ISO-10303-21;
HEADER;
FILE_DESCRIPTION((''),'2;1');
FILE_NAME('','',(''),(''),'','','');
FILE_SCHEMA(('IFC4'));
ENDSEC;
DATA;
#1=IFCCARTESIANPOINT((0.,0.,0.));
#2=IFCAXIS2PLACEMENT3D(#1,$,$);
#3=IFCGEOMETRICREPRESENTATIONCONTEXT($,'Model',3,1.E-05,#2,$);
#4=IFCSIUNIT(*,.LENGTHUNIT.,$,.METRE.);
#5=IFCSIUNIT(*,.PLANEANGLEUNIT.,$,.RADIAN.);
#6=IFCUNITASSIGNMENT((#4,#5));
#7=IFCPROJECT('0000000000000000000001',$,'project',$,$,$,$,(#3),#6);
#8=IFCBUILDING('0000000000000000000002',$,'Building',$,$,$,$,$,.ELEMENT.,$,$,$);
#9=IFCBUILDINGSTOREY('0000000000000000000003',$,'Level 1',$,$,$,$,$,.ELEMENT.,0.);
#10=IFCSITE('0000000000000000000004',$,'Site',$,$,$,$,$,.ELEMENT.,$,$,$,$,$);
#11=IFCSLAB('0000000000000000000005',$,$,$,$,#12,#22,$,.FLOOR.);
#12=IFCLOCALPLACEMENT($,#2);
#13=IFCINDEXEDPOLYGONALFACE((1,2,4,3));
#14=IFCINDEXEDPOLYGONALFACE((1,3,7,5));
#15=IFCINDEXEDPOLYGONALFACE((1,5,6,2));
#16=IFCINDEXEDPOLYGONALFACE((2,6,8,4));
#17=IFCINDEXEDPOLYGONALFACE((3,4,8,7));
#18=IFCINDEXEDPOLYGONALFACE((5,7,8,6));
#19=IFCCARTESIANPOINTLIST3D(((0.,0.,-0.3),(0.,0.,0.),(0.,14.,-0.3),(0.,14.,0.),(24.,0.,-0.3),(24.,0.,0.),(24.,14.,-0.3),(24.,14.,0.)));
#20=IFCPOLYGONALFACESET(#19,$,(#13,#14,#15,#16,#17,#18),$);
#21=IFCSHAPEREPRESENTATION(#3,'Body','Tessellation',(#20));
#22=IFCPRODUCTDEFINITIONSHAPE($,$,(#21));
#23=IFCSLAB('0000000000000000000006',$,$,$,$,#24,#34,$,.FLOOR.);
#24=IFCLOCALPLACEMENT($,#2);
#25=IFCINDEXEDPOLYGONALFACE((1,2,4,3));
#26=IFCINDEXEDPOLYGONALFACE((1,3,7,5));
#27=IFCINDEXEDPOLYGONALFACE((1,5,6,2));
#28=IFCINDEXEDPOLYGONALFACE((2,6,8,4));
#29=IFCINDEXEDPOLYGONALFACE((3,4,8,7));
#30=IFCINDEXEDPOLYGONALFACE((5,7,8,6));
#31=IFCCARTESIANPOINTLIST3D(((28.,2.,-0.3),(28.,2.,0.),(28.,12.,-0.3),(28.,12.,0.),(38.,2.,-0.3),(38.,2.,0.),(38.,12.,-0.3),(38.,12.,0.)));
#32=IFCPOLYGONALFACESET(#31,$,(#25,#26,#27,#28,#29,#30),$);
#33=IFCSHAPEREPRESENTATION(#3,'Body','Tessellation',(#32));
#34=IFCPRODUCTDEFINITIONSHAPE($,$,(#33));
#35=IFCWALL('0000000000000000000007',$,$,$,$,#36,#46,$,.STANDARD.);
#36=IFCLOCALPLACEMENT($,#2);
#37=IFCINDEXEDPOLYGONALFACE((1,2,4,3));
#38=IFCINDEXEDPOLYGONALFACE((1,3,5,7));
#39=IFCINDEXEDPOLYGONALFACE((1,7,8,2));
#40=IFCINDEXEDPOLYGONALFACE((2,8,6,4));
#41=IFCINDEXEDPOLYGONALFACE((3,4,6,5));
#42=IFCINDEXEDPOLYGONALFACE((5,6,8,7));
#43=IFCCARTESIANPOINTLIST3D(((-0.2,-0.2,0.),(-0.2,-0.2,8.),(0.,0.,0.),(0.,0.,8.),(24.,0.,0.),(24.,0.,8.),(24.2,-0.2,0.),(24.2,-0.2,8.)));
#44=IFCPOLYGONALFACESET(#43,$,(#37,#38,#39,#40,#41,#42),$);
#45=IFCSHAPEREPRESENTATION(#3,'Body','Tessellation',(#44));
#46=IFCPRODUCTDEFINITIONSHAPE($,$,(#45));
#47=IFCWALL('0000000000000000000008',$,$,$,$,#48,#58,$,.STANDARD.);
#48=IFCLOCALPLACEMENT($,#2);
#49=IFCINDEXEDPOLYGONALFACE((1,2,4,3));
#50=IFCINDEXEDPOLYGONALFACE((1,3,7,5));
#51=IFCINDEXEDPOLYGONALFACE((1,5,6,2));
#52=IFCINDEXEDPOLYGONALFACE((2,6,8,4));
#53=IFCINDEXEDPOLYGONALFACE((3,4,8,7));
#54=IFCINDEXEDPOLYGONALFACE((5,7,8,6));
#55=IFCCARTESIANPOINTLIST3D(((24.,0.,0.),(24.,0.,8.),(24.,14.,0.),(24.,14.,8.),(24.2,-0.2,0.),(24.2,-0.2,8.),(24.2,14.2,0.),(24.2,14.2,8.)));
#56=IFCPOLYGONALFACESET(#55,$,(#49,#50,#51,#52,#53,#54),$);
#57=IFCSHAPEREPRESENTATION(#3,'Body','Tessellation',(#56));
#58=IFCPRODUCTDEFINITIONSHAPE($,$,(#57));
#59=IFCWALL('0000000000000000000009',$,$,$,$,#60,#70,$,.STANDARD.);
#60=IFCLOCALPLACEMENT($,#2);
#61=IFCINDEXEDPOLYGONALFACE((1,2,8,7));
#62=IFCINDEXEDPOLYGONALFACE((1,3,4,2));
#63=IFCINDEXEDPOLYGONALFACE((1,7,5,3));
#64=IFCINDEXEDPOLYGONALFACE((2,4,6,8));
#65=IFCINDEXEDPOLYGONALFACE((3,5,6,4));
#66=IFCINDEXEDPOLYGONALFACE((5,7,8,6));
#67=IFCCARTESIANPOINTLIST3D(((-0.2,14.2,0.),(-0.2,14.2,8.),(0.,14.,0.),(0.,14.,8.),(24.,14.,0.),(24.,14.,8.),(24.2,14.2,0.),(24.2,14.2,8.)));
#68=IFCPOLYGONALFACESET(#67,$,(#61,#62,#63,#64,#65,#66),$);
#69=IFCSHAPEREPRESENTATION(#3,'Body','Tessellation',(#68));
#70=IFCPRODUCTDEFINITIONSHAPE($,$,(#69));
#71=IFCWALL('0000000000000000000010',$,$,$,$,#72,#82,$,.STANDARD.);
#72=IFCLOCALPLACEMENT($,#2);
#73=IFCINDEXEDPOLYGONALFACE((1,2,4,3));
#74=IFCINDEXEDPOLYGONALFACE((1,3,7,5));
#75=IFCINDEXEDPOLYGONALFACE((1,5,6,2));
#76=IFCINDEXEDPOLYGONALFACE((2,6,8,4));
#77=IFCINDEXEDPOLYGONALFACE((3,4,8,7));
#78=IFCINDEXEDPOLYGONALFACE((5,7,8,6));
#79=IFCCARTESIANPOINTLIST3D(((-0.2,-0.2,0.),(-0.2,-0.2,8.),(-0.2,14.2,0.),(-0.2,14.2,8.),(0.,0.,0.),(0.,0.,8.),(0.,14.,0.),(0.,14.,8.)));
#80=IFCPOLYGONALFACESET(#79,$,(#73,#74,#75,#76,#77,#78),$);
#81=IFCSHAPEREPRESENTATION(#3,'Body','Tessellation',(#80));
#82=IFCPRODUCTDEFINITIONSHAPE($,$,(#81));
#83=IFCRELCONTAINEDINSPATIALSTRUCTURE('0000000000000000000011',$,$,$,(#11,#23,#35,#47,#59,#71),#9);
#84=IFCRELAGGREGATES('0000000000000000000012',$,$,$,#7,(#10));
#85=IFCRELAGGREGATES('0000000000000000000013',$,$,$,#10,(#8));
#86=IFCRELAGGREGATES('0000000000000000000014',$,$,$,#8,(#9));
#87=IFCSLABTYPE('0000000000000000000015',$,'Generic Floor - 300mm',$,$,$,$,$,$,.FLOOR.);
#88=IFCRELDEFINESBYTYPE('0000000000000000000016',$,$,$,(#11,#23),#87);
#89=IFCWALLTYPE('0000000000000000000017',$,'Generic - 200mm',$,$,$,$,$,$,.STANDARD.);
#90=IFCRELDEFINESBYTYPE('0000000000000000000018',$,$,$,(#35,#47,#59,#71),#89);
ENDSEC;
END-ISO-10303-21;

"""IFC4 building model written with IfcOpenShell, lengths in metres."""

from ifc_helpers import new_model, si_unit, frame, origin, place, context, project, spatial, polyline, outline, extrude, type_object, element, save


model = new_model("IFC4")

# Units and contexts
model_context = context("Model", 3, precision=1e-05, world=origin())
ifc_project = project(units=[si_unit("LENGTHUNIT", "METRE"), si_unit("PLANEANGLEUNIT", "RADIAN")], contexts=[model_context])

# Site, building, storey
site = spatial("IfcSite", under=ifc_project, Name="Site", CompositionType="ELEMENT")
building = spatial("IfcBuilding", under=site, Name="Building", CompositionType="ELEMENT")
storey = spatial("IfcBuildingStorey", under=building, Name="Level 1", CompositionType="ELEMENT", Elevation=0.0)

# Slabs
slab_type = type_object("IfcSlabType", Name="Generic Floor - 300mm", PredefinedType="FLOOR")
slab_1_placement = place(None, origin())
element("IfcSlab", 1, at=slab_1_placement, inside=storey, type_object=slab_type, PredefinedType="FLOOR", context=model_context, shape_type="SweptSolid", body=[
    extrude(outline(polyline([(0.0, 14.0), (0.0, 0.0), (24.0, 0.0), (24.0, 14.0), (0.0, 14.0)])), origin(), (0.0, 0.0, -1.0), 0.3),
])
slab_2_placement = place(None, origin())
element("IfcSlab", 2, at=slab_2_placement, inside=storey, type_object=slab_type, PredefinedType="FLOOR", context=model_context, shape_type="SweptSolid", body=[
    extrude(outline(polyline([(28.0, 12.0), (28.0, 2.0), (38.0, 2.0), (38.0, 12.0), (28.0, 12.0)])), origin(), (0.0, 0.0, -1.0), 0.3),
])

# Walls
wall_type = type_object("IfcWallType", Name="Generic - 200mm", PredefinedType="STANDARD")
wall_1_placement = place(None, frame((24.0, -0.1, 0.0), z_axis=(0.0, 0.0, 1.0), x_axis=(-1.0, 0.0, 0.0)))
element("IfcWall", 3, at=wall_1_placement, inside=storey, type_object=wall_type, PredefinedType="STANDARD", context=model_context, shape_type="SweptSolid", body=[
    extrude(outline(polyline([(0.0, -0.1), (24.0, -0.1), (24.2, 0.1), (-0.2, 0.1), (0.0, -0.1)])), origin(), (0.0, 0.0, 1.0), 8.0),
])
wall_2_placement = place(None, frame((24.1, 14.0, 0.0), z_axis=(0.0, 0.0, 1.0), x_axis=(0.0, -1.0, 0.0)))
element("IfcWall", 4, at=wall_2_placement, inside=storey, type_object=wall_type, PredefinedType="STANDARD", context=model_context, shape_type="SweptSolid", body=[
    extrude(outline(polyline([(0.0, -0.1), (14.0, -0.1), (14.2, 0.1), (-0.2, 0.1), (0.0, -0.1)])), origin(), (0.0, 0.0, 1.0), 8.0),
])
wall_3_placement = place(None, frame((0.0, 14.1, 0.0), z_axis=(0.0, 0.0, 1.0), x_axis=(1.0, 0.0, 0.0)))
element("IfcWall", 5, at=wall_3_placement, inside=storey, type_object=wall_type, PredefinedType="STANDARD", context=model_context, shape_type="SweptSolid", body=[
    extrude(outline(polyline([(0.0, -0.1), (24.0, -0.1), (24.2, 0.1), (-0.2, 0.1), (0.0, -0.1)])), origin(), (0.0, 0.0, 1.0), 8.0),
])
wall_4_placement = place(None, frame((-0.1, 0.0, 0.0), z_axis=(0.0, 0.0, 1.0), x_axis=(0.0, 1.0, 0.0)))
element("IfcWall", 6, at=wall_4_placement, inside=storey, type_object=wall_type, PredefinedType="STANDARD", context=model_context, shape_type="SweptSolid", body=[
    extrude(outline(polyline([(0.0, -0.1), (14.0, -0.1), (14.2, 0.1), (-0.2, 0.1), (0.0, -0.1)])), origin(), (0.0, 0.0, 1.0), 8.0),
])

save(model, "model.ifc")
